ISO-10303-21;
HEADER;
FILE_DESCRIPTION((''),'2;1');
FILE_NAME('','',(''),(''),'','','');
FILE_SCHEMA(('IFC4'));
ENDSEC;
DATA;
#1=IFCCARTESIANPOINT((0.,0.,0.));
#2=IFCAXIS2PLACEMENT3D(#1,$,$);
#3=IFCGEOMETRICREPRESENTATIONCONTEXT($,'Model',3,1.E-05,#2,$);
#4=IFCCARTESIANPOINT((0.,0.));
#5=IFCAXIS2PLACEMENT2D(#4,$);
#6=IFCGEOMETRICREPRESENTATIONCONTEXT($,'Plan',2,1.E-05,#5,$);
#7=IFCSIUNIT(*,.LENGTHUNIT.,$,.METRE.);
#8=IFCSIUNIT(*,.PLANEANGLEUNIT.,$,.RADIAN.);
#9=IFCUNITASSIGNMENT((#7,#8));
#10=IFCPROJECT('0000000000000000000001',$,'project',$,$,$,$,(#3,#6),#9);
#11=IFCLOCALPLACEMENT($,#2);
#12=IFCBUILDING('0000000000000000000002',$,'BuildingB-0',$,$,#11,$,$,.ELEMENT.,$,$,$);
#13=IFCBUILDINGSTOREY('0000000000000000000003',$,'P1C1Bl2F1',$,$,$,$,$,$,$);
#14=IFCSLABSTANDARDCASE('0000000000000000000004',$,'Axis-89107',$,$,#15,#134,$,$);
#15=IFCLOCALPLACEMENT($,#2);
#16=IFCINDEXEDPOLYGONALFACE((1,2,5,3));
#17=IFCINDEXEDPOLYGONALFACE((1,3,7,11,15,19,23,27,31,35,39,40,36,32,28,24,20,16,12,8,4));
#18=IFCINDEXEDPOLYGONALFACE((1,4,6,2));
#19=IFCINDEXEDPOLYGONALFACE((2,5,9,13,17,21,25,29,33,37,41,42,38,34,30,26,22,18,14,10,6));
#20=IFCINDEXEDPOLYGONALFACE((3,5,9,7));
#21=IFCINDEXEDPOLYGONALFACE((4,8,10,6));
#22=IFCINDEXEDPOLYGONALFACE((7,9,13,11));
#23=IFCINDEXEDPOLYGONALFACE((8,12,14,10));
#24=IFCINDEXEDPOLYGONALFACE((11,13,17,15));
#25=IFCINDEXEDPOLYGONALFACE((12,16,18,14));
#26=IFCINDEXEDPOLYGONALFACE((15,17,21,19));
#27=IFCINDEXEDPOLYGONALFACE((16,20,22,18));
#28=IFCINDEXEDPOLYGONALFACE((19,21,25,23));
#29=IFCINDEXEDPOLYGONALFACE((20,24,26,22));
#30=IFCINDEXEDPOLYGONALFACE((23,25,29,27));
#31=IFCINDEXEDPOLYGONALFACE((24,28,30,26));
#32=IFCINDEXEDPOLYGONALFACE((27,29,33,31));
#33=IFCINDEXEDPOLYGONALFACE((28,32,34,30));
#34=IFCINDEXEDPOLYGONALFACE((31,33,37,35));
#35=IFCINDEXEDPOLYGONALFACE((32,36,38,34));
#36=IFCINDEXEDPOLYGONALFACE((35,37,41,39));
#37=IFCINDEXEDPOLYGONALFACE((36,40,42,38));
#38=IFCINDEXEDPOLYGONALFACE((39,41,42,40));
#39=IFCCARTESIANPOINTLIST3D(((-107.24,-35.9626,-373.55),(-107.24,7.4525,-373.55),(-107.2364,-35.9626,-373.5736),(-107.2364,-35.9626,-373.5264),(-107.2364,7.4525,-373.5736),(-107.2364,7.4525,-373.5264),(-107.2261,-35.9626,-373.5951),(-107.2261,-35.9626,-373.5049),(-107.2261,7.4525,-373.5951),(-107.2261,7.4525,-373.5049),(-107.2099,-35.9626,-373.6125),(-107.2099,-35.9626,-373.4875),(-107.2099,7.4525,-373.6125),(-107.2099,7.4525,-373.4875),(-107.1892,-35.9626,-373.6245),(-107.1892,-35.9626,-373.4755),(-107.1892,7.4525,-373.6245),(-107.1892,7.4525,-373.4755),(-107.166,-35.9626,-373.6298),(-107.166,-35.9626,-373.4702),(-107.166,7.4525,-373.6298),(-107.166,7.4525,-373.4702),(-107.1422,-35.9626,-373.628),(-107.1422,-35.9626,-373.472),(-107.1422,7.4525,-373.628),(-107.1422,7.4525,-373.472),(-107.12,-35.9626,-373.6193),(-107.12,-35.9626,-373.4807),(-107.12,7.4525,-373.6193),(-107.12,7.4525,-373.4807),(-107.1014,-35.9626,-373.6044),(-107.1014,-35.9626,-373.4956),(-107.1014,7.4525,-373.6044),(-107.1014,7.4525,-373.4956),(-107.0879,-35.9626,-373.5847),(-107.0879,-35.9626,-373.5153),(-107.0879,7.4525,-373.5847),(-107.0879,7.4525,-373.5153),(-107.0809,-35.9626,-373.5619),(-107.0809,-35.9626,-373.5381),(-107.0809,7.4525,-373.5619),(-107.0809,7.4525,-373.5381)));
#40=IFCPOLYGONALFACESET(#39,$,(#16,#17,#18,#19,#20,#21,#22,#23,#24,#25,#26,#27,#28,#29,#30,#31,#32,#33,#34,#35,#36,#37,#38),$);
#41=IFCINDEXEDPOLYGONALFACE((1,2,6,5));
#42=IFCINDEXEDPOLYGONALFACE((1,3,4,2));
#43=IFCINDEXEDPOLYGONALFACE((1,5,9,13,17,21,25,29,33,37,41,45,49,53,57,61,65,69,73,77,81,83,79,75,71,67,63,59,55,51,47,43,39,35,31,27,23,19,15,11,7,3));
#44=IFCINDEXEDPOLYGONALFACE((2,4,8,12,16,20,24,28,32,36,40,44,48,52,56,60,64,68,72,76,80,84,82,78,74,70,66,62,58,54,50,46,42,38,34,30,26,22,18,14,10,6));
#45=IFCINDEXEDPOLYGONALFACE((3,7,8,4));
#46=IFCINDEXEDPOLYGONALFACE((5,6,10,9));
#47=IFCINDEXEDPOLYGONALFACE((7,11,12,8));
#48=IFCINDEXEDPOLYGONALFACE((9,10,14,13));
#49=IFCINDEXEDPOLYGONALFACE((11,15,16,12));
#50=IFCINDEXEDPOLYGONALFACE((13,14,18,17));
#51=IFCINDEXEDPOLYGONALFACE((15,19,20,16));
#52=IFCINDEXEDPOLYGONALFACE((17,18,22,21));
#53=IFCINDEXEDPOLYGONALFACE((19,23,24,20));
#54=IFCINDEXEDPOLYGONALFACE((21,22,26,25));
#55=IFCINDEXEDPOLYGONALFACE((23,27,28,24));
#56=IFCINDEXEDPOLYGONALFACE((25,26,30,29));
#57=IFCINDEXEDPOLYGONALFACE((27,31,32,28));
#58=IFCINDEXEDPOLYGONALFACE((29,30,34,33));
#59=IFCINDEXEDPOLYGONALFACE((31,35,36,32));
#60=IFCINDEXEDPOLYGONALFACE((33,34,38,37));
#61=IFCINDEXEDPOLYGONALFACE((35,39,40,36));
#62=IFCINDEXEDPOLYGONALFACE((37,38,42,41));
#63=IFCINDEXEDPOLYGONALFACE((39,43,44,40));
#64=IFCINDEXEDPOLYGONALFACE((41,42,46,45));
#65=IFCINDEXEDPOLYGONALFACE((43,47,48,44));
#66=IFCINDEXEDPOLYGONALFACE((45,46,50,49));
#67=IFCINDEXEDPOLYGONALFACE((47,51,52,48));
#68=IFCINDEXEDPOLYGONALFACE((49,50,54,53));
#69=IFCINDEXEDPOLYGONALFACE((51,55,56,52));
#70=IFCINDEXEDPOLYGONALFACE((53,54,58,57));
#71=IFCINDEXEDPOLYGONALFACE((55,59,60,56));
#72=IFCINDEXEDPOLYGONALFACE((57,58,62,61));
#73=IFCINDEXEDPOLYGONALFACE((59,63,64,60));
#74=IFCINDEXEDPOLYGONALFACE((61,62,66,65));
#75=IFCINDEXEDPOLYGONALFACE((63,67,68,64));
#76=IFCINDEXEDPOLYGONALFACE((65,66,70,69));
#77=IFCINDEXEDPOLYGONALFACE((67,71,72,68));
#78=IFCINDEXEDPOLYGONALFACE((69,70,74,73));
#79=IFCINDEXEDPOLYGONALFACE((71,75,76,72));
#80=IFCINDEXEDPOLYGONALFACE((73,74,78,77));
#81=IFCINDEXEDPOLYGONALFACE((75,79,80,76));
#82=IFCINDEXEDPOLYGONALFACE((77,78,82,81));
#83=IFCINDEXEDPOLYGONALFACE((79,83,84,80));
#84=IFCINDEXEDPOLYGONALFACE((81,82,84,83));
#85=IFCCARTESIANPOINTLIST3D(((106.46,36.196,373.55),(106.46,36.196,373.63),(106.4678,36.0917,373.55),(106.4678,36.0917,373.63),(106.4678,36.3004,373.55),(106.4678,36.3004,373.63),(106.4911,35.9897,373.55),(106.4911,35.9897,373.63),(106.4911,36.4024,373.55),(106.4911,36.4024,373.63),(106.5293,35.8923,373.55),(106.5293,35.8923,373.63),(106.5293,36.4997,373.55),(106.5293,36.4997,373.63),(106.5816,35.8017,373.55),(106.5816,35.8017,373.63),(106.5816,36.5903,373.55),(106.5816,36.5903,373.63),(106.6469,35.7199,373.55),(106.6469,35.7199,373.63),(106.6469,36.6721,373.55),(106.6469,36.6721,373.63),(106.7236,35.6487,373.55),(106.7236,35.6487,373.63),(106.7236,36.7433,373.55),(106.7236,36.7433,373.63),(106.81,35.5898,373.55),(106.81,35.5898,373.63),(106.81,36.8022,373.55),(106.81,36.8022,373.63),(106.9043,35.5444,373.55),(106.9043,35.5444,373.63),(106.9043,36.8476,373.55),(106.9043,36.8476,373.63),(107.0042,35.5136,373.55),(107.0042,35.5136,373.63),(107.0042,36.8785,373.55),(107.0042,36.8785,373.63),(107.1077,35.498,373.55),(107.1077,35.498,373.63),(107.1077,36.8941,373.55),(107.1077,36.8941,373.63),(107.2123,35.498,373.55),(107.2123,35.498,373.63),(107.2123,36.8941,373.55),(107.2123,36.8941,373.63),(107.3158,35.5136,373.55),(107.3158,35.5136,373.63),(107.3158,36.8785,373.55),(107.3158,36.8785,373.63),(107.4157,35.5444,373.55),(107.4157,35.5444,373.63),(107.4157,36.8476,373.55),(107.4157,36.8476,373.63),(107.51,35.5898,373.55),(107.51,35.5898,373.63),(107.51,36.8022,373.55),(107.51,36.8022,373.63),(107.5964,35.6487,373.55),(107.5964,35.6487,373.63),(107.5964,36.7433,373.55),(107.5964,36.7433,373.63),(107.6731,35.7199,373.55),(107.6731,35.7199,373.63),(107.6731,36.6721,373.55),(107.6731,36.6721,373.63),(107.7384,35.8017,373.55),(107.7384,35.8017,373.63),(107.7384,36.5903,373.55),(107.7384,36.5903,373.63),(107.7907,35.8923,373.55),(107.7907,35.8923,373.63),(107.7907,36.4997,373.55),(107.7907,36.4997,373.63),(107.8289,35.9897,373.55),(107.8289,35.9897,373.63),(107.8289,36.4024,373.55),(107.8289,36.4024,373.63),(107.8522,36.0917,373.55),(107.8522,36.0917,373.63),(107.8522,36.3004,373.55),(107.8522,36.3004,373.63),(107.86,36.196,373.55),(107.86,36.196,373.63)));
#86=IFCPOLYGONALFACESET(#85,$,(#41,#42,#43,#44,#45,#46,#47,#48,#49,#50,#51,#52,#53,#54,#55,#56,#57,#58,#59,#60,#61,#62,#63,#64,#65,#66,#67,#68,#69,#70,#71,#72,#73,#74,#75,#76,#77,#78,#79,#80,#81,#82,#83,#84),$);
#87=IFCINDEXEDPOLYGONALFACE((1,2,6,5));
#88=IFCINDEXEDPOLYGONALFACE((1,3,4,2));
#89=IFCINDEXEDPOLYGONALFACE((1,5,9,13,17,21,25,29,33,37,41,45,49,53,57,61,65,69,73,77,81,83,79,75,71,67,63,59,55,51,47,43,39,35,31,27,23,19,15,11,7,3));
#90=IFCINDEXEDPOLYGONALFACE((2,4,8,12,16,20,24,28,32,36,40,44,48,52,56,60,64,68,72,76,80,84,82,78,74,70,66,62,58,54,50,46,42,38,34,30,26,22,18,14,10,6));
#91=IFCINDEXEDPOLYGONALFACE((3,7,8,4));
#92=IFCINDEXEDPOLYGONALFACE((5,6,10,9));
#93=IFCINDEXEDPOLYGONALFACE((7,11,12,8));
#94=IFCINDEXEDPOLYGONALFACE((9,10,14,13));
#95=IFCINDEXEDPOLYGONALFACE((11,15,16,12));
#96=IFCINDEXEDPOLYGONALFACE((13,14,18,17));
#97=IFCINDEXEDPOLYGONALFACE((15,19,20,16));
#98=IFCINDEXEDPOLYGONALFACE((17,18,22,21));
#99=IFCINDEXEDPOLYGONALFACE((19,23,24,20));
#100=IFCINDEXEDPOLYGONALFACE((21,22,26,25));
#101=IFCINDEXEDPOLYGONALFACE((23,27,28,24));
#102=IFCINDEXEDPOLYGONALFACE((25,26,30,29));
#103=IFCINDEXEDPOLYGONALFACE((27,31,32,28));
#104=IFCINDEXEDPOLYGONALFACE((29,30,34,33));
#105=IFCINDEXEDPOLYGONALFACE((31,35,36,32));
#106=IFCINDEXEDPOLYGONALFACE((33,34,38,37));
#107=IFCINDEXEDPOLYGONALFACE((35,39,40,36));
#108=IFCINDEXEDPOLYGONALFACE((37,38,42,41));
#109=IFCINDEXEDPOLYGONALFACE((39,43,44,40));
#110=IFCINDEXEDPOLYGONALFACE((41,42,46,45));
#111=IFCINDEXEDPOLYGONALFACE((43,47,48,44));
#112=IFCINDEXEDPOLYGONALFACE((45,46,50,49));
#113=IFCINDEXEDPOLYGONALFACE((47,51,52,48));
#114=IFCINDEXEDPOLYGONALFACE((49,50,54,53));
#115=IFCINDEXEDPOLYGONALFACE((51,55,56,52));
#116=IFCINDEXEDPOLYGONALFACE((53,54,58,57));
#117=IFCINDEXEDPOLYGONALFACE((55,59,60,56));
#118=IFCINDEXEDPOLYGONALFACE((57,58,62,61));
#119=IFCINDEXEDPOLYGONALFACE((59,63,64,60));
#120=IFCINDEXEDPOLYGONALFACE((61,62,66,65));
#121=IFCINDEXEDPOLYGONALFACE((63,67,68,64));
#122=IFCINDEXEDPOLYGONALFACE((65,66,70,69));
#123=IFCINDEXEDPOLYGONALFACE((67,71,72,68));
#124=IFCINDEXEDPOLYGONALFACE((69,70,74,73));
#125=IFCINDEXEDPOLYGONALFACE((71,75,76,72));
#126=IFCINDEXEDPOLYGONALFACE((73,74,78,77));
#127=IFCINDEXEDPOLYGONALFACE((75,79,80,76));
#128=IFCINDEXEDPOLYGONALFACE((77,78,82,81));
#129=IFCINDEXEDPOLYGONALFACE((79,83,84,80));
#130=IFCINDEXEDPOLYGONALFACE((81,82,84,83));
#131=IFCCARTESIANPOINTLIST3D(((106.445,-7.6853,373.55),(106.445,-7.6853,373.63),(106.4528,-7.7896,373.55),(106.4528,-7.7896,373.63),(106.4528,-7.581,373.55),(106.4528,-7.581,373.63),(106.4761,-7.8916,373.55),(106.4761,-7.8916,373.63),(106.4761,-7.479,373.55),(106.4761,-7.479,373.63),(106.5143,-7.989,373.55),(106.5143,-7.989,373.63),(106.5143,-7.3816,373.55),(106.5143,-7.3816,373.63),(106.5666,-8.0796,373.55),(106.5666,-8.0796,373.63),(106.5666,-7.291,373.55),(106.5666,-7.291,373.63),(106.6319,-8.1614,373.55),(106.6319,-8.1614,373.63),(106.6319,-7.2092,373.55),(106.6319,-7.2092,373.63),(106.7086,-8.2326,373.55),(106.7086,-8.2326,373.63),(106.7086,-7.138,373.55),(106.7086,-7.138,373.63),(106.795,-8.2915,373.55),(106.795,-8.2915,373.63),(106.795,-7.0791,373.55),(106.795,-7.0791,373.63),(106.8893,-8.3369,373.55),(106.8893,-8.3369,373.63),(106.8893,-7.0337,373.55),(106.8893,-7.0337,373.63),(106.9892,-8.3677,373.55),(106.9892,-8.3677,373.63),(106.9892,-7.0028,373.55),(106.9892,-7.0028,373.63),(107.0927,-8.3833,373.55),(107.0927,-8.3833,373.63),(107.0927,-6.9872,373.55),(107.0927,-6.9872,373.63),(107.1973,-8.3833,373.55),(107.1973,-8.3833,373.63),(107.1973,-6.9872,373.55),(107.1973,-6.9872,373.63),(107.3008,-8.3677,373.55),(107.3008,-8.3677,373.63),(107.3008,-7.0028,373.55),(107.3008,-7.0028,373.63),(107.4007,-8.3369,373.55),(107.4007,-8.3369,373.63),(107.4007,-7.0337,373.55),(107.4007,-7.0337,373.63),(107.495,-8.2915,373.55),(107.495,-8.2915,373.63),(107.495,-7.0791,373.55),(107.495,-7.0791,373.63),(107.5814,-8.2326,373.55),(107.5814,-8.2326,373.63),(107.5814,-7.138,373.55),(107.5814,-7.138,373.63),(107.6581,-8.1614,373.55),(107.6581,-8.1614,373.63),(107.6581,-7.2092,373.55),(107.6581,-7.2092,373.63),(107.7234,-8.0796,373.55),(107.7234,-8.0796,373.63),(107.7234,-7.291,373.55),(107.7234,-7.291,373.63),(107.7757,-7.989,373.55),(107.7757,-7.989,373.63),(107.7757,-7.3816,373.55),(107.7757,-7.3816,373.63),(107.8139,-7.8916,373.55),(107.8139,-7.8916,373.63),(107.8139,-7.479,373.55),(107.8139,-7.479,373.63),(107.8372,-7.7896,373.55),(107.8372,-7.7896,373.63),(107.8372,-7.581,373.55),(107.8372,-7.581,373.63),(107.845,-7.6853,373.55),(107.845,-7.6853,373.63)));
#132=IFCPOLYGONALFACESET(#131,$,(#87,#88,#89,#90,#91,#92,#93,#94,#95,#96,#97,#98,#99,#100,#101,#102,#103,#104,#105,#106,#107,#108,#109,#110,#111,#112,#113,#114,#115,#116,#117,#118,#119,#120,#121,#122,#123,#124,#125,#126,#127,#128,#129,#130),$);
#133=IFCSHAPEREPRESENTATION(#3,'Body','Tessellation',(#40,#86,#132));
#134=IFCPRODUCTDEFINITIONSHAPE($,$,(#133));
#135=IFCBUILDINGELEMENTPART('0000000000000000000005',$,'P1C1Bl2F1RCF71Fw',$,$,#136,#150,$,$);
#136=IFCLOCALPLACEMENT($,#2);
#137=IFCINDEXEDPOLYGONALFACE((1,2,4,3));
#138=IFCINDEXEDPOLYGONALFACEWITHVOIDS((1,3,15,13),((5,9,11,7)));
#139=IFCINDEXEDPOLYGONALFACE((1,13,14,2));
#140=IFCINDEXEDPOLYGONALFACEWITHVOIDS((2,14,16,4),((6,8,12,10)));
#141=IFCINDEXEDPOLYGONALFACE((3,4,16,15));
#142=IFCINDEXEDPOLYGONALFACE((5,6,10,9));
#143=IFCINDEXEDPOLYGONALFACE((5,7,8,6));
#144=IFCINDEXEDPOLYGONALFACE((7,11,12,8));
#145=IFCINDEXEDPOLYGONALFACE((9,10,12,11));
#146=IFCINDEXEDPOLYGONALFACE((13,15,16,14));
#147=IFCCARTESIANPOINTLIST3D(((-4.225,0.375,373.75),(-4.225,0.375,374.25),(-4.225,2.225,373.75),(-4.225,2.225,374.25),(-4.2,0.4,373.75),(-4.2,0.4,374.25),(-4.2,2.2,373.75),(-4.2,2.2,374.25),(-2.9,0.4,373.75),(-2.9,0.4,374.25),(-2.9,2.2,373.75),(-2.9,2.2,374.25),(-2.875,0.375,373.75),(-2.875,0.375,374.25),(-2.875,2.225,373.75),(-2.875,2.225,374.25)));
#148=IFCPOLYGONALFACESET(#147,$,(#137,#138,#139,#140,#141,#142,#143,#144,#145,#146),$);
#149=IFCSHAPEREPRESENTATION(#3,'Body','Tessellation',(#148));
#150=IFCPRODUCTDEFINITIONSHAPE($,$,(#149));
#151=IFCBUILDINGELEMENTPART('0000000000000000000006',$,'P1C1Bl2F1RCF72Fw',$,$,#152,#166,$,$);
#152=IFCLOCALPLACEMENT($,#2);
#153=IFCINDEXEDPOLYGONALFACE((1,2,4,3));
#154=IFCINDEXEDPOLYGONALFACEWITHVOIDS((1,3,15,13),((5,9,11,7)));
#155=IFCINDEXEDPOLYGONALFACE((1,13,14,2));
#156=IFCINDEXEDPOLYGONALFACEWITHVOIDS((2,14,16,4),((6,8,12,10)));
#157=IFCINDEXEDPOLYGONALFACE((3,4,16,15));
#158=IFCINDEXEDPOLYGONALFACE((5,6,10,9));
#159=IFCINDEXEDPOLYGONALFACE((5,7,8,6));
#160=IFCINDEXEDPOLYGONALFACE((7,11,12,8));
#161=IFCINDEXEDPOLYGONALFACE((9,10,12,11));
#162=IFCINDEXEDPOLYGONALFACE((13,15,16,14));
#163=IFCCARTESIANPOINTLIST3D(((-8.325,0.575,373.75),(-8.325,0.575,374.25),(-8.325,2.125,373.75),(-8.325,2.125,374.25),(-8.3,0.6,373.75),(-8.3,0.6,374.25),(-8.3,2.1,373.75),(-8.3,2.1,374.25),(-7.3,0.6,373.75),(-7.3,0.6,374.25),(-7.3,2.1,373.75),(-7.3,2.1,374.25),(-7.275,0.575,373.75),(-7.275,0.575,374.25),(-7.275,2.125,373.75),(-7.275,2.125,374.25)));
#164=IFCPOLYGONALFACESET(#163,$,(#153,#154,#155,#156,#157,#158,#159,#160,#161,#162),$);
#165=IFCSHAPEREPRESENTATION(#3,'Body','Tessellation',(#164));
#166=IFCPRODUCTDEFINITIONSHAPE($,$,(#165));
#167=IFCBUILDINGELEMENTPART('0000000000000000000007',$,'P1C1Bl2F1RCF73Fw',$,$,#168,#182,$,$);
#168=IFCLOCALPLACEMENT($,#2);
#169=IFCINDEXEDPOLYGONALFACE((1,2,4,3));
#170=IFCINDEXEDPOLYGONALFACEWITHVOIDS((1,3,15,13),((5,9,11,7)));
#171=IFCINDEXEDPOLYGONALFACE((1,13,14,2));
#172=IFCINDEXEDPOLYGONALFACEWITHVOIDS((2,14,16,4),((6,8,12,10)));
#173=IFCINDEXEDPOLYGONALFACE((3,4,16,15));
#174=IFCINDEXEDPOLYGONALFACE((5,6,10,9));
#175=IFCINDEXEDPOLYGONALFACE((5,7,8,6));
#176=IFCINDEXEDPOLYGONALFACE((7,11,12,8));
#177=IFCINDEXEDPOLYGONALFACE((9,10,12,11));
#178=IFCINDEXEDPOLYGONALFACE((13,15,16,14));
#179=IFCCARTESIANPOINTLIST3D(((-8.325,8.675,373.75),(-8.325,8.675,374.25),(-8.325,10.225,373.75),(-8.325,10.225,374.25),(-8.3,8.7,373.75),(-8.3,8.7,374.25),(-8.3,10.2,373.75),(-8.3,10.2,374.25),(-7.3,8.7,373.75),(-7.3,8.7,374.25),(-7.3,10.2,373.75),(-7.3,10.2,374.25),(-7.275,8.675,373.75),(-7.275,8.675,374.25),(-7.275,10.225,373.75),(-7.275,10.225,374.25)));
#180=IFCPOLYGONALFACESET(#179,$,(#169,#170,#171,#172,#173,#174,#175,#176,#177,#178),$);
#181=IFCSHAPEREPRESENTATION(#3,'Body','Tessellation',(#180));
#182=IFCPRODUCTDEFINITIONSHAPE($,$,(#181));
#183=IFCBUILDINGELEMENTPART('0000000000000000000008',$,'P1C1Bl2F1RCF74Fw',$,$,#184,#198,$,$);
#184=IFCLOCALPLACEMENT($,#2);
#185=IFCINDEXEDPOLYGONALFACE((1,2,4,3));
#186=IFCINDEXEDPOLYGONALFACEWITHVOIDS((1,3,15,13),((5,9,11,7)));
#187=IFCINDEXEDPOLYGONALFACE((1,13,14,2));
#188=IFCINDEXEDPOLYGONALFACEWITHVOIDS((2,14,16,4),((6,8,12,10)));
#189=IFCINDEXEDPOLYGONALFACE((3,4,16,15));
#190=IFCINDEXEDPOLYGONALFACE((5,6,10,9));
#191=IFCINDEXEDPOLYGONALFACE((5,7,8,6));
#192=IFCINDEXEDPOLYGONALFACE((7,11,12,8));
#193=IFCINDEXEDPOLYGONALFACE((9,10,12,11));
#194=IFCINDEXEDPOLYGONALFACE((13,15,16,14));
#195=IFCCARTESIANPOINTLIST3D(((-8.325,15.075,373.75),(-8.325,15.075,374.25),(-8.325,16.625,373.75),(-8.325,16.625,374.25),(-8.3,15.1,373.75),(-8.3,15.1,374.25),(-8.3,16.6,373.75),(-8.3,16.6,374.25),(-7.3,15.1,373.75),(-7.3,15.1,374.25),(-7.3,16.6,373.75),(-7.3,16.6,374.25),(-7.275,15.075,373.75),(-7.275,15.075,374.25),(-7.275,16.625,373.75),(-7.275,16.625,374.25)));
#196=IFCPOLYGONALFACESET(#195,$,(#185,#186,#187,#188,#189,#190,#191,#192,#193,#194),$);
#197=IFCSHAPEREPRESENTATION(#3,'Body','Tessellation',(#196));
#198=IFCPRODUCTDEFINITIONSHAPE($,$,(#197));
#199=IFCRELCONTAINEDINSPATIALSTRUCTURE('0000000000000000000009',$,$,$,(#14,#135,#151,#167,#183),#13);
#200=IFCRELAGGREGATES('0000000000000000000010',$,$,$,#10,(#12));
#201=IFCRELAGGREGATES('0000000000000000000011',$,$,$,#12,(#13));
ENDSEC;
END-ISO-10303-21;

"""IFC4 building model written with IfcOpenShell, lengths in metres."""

from ifc_helpers import new_model, entity, si_unit, frame, origin, origin_2d, place, context, project, spatial, polyline, circle, outline, extrude, element, save


model = new_model("IFC4")

# Units and contexts
model_context = context("Model", 3, precision=1e-05, world=origin())
plan_context = context("Plan", 2, precision=1e-05, world=origin_2d())
ifc_project = project(units=[si_unit("LENGTHUNIT", "METRE"), si_unit("PLANEANGLEUNIT", "RADIAN")], contexts=[model_context, plan_context])

# Building, storey
building_placement = place(None, origin())
building = spatial("IfcBuilding", under=ifc_project, at=building_placement, Name="BuildingB-0", CompositionType="ELEMENT")
storey = spatial("IfcBuildingStorey", under=building, Name="P1C1Bl2F1")

# Slab
element("IfcSlabStandardCase", 1, inside=storey, Name="Axis-89107", context=model_context, shape_type="AdvancedSweptSolid", body=[
    entity("IfcSurfaceCurveSweptAreaSolid", entity("IfcCircleProfileDef", "AREA", None, None, 0.08), None, entity("IfcPolyline", [entity("IfcCartesianPoint", [107.16, 35.9626, 373.55]), entity("IfcCartesianPoint", [107.16, -7.4525, 373.55])]), None, None, entity("IfcPlane", entity("IfcAxis2Placement3D", entity("IfcCartesianPoint", [107.16, 35.9626, 373.55]), entity("IfcDirection", [0.0, 0.0, 1.0]), entity("IfcDirection", [1.0, 0.0, 0.0])))),
    extrude(circle(Radius=0.7), frame((107.16, 36.196, 373.55)), (0.0, 0.0, 1.0), 0.08),
    extrude(circle(Radius=0.7), frame((107.145, -7.6853, 373.55)), (0.0, 0.0, 1.0), 0.08),
])

# Building element part, opening
building_element_part_1 = element("IfcBuildingElementPart", 2, inside=storey, Name="P1C1Bl2F1RCF71Fw", context=model_context, shape_type="SweptSolid", body=[
    extrude(outline(polyline([(-2.875, 2.225, 373.75), (-4.225, 2.225, 373.75), (-4.225, 0.375, 373.75), (-2.875, 0.375, 373.75), (-2.875, 2.225, 373.75)])), None, (0.0, 0.0, 1.0), 0.5),
])
element("IfcOpeningElement", 3, inside=storey, cuts=building_element_part_1, context=model_context, shape_type="SweptSolid", body=[
    extrude(outline(polyline([(-2.9, 2.2, 373.75), (-4.2, 2.2, 373.75), (-4.2, 0.4, 373.75), (-2.9, 0.4, 373.75), (-2.9, 2.2, 373.75)])), None, (0.0, 0.0, 1.0), 0.5),
])

# Building element part, opening
building_element_part_2 = element("IfcBuildingElementPart", 4, inside=storey, Name="P1C1Bl2F1RCF72Fw", context=model_context, shape_type="SweptSolid", body=[
    extrude(outline(polyline([(-7.275, 2.125, 373.75), (-8.325, 2.125, 373.75), (-8.325, 0.575, 373.75), (-7.275, 0.575, 373.75), (-7.275, 2.125, 373.75)])), None, (0.0, 0.0, 1.0), 0.5),
])
element("IfcOpeningElement", 5, inside=storey, cuts=building_element_part_2, context=model_context, shape_type="SweptSolid", body=[
    extrude(outline(polyline([(-7.3, 2.1, 373.75), (-8.3, 2.1, 373.75), (-8.3, 0.6, 373.75), (-7.3, 0.6, 373.75), (-7.3, 2.1, 373.75)])), None, (0.0, 0.0, 1.0), 0.5),
])

# Building element part, opening
building_element_part_3 = element("IfcBuildingElementPart", 6, inside=storey, Name="P1C1Bl2F1RCF73Fw", context=model_context, shape_type="SweptSolid", body=[
    extrude(outline(polyline([(-7.275, 10.225, 373.75), (-8.325, 10.225, 373.75), (-8.325, 8.675, 373.75), (-7.275, 8.675, 373.75), (-7.275, 10.225, 373.75)])), None, (0.0, 0.0, 1.0), 0.5),
])
element("IfcOpeningElement", 7, inside=storey, cuts=building_element_part_3, context=model_context, shape_type="SweptSolid", body=[
    extrude(outline(polyline([(-7.3, 10.2, 373.75), (-8.3, 10.2, 373.75), (-8.3, 8.7, 373.75), (-7.3, 8.7, 373.75), (-7.3, 10.2, 373.75)])), None, (0.0, 0.0, 1.0), 0.5),
])

# Building element part, opening
building_element_part_4 = element("IfcBuildingElementPart", 8, inside=storey, Name="P1C1Bl2F1RCF74Fw", context=model_context, shape_type="SweptSolid", body=[
    extrude(outline(polyline([(-7.275, 16.625, 373.75), (-8.325, 16.625, 373.75), (-8.325, 15.075, 373.75), (-7.275, 15.075, 373.75), (-7.275, 16.625, 373.75)])), None, (0.0, 0.0, 1.0), 0.5),
])
element("IfcOpeningElement", 9, inside=storey, cuts=building_element_part_4, context=model_context, shape_type="SweptSolid", body=[
    extrude(outline(polyline([(-7.3, 16.6, 373.75), (-8.3, 16.6, 373.75), (-8.3, 15.1, 373.75), (-7.3, 15.1, 373.75), (-7.3, 16.6, 373.75)])), None, (0.0, 0.0, 1.0), 0.5),
])

save(model, "model.ifc")
